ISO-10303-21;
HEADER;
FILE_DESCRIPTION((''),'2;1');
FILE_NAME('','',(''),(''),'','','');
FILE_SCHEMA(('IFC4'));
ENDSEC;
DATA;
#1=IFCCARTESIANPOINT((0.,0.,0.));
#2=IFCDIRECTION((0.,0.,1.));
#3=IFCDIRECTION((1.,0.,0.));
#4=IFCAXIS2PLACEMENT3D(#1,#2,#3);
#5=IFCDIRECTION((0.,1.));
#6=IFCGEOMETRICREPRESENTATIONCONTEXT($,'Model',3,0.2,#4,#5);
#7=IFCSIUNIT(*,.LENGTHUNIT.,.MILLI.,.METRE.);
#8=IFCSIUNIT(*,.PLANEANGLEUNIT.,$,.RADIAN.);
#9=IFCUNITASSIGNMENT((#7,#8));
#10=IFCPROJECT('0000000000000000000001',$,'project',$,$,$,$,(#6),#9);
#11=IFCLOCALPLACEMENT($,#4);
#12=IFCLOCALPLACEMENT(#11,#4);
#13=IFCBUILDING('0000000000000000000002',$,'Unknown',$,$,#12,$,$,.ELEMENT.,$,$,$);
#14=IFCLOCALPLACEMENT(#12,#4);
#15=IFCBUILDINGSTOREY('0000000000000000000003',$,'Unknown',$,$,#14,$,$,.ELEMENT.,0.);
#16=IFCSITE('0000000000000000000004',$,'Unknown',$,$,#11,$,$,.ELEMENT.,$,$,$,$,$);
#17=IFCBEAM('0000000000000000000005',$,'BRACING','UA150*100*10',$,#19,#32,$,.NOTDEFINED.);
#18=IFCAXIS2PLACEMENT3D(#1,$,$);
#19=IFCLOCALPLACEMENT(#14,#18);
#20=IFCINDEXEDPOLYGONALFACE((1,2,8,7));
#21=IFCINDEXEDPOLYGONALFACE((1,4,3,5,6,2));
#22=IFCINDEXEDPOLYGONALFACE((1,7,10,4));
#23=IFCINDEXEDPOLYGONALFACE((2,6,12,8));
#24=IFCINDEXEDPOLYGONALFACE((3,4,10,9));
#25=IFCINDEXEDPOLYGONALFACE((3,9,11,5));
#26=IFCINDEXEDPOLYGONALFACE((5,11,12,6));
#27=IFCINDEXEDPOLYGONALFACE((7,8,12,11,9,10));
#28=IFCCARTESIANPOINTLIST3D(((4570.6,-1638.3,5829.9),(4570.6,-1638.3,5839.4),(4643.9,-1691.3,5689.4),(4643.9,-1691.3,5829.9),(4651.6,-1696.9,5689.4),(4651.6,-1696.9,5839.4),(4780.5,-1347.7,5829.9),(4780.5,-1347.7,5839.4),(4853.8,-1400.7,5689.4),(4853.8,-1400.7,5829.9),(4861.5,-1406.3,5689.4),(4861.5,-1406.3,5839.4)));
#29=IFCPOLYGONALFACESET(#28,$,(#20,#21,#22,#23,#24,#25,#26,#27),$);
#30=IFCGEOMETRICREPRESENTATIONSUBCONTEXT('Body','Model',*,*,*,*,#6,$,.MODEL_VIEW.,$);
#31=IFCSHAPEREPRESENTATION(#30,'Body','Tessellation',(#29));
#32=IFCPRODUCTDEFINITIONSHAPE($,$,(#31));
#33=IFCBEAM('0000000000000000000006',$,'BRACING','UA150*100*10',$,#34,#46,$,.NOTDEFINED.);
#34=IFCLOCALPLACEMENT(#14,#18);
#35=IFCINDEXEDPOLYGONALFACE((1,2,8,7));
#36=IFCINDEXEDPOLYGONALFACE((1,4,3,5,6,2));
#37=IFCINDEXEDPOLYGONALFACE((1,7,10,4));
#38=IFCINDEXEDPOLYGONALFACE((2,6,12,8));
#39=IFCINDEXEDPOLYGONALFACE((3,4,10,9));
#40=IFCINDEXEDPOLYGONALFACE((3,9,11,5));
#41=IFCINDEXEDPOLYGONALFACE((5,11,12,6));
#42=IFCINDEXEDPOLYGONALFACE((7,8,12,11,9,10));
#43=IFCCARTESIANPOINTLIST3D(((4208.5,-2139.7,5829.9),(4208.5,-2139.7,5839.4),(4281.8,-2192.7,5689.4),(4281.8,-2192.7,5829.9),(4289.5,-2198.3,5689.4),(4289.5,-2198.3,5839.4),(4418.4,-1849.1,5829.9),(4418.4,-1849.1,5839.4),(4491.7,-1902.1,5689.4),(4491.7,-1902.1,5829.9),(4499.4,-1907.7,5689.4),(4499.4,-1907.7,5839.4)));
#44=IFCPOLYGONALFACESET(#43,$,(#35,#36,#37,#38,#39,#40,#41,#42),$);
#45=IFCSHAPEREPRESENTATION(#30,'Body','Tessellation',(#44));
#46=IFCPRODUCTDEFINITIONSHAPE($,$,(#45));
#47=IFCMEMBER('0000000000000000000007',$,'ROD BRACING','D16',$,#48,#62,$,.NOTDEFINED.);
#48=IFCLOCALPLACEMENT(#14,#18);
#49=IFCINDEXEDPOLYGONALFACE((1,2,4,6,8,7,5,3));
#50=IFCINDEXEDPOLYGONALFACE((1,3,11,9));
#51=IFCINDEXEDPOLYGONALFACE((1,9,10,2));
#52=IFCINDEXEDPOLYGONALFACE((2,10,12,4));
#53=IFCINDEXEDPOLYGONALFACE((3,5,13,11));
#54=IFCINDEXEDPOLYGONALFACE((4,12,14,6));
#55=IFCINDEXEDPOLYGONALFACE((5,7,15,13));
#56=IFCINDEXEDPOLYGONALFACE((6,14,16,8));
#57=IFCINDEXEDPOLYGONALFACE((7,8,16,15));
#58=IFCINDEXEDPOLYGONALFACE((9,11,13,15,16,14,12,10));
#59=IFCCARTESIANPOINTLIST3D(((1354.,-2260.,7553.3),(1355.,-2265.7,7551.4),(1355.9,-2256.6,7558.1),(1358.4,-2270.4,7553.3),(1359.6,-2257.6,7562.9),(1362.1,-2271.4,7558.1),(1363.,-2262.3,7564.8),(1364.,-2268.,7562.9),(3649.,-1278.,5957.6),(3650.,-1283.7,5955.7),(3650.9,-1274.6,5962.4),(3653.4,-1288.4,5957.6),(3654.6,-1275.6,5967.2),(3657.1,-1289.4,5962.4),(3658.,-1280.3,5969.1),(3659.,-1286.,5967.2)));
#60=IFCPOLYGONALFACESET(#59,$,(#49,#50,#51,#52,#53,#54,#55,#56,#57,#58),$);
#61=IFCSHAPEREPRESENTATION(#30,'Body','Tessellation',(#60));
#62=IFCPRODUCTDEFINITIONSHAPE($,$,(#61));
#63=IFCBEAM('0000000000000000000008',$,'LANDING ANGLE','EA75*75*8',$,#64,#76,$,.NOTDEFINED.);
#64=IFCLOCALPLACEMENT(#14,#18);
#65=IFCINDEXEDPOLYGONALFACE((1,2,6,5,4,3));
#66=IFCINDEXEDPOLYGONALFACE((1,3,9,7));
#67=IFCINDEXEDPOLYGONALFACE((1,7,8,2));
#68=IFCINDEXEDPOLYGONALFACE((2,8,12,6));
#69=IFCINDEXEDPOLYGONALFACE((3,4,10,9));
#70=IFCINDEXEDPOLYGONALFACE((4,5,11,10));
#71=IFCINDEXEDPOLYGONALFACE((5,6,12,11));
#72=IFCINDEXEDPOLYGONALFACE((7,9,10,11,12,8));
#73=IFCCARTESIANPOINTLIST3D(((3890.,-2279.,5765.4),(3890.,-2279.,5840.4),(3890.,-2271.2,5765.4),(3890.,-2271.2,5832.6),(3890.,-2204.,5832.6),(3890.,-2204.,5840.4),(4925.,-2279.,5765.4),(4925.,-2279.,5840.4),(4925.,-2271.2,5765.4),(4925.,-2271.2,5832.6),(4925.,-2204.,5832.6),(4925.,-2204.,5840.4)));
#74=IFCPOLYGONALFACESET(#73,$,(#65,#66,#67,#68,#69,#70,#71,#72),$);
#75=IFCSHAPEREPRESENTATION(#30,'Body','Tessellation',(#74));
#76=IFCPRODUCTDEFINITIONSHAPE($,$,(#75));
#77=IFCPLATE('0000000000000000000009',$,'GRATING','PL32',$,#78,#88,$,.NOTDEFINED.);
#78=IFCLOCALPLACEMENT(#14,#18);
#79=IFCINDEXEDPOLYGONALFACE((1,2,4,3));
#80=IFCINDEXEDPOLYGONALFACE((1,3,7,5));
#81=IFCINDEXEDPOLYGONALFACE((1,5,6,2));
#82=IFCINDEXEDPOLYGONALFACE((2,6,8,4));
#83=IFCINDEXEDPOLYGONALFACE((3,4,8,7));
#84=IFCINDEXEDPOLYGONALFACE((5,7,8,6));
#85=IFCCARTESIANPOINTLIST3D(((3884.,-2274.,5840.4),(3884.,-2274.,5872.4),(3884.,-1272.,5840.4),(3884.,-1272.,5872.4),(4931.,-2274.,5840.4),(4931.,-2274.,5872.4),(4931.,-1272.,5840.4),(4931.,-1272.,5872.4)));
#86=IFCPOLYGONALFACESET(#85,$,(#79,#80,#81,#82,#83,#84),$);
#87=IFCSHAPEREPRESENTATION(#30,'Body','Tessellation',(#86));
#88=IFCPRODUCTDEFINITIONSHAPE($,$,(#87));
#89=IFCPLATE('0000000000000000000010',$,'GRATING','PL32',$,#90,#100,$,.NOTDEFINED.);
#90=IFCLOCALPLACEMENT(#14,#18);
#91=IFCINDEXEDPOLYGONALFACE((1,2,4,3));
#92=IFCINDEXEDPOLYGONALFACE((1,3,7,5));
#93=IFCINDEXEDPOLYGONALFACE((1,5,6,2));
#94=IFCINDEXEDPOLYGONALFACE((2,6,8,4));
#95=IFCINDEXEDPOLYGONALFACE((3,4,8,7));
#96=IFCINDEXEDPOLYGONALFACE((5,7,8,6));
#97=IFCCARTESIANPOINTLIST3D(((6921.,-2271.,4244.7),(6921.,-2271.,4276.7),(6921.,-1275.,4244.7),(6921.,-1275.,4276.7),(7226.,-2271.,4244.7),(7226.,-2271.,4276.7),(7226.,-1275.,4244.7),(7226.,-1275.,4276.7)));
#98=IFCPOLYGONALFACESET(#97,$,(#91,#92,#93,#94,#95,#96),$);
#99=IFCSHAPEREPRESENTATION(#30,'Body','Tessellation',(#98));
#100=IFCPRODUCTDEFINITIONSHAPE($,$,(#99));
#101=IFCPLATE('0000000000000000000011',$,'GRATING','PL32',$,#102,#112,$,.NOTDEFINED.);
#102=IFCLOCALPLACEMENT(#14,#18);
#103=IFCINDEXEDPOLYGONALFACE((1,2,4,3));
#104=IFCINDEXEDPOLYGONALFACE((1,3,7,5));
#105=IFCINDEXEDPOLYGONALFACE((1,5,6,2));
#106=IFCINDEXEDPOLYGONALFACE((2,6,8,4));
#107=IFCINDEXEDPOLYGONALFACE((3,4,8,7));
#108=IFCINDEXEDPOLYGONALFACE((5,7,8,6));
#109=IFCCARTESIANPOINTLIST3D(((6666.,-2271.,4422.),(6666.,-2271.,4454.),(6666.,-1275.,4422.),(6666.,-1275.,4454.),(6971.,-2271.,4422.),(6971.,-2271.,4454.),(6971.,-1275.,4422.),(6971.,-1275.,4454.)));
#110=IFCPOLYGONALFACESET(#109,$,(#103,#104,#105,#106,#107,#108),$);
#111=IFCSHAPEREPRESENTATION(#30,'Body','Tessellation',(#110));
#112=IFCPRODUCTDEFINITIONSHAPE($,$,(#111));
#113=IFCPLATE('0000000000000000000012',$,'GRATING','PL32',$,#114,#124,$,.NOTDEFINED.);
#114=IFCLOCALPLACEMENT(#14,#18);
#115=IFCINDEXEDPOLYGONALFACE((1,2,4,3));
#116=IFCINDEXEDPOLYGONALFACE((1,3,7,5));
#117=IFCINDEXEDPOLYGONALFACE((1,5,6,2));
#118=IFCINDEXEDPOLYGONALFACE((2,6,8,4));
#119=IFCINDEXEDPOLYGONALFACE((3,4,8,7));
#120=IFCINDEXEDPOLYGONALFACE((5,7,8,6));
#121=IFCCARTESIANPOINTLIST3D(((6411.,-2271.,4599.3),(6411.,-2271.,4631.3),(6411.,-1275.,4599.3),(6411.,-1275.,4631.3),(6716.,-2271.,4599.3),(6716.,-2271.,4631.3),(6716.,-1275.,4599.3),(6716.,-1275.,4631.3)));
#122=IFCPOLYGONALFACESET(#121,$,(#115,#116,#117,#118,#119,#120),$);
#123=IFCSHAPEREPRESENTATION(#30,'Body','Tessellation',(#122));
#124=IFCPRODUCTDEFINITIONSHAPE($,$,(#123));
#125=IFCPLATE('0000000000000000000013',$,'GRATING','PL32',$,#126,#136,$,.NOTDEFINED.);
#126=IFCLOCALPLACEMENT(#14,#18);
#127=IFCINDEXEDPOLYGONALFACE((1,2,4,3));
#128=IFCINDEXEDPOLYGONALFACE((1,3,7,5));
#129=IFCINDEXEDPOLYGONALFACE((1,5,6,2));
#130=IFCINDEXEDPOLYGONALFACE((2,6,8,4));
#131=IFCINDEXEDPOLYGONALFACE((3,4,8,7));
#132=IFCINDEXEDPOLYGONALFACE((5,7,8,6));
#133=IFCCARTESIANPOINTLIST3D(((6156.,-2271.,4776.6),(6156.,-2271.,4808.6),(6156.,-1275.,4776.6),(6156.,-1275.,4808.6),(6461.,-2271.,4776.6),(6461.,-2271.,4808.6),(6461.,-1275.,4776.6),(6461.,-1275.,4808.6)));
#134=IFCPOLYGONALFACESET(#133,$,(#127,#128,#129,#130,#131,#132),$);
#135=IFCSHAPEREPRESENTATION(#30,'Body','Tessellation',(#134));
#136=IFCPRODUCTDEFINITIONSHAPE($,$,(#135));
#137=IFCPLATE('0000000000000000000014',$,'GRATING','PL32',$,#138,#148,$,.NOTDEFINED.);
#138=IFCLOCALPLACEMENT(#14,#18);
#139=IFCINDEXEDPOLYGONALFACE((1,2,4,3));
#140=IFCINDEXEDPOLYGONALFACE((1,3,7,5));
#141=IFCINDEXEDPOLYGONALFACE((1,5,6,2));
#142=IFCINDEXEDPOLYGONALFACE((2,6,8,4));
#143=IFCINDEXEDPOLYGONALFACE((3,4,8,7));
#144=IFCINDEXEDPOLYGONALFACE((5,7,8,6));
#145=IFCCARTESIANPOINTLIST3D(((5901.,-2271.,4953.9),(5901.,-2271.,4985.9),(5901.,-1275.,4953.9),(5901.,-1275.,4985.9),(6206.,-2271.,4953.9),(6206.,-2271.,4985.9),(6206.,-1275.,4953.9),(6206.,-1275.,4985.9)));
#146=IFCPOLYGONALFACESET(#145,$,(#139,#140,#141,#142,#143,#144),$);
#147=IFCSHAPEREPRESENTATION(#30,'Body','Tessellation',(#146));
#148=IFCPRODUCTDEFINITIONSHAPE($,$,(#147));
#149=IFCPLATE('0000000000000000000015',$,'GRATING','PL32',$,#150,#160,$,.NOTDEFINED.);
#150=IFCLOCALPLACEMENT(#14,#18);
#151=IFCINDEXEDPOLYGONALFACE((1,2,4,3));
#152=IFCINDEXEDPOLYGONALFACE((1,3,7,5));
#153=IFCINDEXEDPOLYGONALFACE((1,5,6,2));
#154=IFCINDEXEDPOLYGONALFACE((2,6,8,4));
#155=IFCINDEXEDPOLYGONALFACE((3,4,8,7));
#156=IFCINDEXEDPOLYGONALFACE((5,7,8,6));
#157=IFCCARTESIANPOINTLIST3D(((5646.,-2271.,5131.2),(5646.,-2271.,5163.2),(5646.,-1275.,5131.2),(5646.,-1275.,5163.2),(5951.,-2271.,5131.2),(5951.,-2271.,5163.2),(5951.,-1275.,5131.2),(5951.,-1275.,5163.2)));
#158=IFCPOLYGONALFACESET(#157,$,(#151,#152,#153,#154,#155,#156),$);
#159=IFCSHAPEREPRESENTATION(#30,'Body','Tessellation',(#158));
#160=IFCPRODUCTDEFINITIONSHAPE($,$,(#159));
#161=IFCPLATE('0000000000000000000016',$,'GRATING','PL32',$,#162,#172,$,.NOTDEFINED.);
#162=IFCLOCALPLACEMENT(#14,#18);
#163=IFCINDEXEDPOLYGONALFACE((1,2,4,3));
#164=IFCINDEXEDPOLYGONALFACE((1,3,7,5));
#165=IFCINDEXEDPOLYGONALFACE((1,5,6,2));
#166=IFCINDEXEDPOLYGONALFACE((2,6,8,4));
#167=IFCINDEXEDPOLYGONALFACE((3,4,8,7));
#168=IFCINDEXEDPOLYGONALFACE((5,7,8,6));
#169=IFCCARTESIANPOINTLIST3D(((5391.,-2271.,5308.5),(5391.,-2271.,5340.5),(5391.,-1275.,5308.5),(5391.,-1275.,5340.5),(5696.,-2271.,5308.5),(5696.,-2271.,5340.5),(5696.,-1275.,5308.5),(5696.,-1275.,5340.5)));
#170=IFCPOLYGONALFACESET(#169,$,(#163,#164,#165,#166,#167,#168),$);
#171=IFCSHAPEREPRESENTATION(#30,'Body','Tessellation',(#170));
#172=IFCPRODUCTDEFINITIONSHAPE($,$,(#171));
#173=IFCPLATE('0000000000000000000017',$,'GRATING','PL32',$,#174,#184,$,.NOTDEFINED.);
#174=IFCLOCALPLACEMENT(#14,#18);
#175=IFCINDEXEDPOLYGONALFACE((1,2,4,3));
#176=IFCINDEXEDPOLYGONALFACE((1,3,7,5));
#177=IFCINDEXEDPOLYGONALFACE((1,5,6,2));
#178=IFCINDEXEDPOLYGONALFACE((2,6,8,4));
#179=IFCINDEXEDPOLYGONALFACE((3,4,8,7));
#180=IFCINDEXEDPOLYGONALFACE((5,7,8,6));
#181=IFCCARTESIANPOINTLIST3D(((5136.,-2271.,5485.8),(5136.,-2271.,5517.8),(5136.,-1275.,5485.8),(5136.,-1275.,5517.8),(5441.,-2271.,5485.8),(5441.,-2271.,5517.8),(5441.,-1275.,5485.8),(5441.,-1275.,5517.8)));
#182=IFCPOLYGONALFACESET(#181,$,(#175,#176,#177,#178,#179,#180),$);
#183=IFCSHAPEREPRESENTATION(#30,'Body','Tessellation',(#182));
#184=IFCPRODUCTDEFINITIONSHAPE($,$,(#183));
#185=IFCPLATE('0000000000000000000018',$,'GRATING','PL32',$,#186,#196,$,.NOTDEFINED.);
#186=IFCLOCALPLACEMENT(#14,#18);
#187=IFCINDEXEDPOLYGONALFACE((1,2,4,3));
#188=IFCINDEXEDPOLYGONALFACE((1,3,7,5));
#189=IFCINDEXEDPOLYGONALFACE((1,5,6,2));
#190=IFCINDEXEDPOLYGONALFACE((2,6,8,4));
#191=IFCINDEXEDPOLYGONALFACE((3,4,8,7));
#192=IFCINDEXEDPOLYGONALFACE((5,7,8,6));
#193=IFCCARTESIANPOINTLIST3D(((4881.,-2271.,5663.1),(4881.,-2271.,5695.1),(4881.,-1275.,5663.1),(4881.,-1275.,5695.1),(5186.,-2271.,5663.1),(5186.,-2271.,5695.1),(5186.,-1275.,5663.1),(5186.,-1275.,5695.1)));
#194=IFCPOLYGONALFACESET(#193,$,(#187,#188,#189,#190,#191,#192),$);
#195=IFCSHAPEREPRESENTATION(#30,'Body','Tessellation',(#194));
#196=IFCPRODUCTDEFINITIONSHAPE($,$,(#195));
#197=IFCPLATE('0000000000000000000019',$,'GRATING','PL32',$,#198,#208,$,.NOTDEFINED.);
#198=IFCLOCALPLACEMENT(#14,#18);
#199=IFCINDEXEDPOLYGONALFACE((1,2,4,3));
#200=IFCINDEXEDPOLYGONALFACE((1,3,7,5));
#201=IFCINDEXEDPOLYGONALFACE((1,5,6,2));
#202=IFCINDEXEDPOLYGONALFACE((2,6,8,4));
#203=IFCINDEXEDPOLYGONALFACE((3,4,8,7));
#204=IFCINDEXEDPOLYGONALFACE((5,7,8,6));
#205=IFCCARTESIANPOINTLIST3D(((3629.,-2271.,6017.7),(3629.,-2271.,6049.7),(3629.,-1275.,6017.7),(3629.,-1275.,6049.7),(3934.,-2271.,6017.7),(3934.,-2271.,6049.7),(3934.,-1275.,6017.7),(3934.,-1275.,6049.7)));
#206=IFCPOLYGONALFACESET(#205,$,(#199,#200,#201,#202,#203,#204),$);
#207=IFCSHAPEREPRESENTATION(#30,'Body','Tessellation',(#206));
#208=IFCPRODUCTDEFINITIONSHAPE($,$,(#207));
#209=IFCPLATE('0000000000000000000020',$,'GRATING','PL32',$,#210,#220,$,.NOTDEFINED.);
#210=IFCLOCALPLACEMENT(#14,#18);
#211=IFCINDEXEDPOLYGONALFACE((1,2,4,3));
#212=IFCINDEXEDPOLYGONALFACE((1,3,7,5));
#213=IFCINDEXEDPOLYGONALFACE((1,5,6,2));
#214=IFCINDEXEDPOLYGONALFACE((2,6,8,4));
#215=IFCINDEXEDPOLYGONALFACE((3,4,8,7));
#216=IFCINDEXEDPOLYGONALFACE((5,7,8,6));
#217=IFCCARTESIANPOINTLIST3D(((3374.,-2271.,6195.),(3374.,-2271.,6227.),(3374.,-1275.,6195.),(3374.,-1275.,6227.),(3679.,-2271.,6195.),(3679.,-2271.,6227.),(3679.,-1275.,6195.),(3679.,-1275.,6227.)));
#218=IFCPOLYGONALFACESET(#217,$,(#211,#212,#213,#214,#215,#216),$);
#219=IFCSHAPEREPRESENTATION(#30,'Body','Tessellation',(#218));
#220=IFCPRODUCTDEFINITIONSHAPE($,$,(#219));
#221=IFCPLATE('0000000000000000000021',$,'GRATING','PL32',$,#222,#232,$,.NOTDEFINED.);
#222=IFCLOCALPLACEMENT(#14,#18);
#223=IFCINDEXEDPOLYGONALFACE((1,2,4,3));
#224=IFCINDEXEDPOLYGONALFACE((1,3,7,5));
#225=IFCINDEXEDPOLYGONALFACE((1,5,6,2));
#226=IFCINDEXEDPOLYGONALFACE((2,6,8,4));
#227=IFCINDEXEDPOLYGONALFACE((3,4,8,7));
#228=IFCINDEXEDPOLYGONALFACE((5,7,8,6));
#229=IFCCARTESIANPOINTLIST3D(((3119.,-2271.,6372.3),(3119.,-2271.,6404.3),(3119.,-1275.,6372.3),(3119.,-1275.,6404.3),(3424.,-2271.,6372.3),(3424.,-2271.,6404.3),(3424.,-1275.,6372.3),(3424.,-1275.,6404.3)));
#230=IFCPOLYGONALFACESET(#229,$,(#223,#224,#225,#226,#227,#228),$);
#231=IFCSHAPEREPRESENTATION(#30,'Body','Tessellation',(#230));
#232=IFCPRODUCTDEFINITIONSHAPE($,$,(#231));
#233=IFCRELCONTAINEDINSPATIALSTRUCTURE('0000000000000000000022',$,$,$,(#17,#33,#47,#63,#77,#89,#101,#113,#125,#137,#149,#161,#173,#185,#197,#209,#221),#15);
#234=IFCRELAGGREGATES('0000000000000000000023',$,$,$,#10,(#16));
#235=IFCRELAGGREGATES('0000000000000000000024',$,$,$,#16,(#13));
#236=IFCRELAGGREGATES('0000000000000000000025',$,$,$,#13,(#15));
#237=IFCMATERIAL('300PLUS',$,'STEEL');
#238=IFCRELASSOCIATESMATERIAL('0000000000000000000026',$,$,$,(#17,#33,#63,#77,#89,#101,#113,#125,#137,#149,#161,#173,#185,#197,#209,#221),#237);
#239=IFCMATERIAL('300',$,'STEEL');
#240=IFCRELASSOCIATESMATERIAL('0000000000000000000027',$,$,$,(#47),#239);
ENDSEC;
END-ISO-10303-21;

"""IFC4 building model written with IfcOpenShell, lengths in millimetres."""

from ifc_helpers import new_model, si_unit, direction, frame, origin_with_axes, place, context, subcontext, project, spatial, line, indexed_curve, outline, extrude, material, element, save


model = new_model("IFC4")

# Units and contexts
model_context = context("Model", 3, precision=0.2, world=origin_with_axes(), true_north=direction((0.0, 1.0)))
body_context = subcontext(model_context, "Body", "Model", "MODEL_VIEW")
ifc_project = project(units=[si_unit("LENGTHUNIT", "METRE", prefix="MILLI"), si_unit("PLANEANGLEUNIT", "RADIAN")], contexts=[model_context])

# Site, building, storey
site_placement = place(None, origin_with_axes())
site = spatial("IfcSite", under=ifc_project, at=site_placement, Name="Unknown", CompositionType="ELEMENT")
building_placement = place(site_placement, origin_with_axes())
building = spatial("IfcBuilding", under=site, at=building_placement, Name="Unknown", CompositionType="ELEMENT")
storey_placement = place(building_placement, origin_with_axes())
storey = spatial("IfcBuildingStorey", under=building, at=storey_placement, Name="Unknown", CompositionType="ELEMENT", Elevation=0.0)

# Beams
ifc_material_1 = material(Name="300PLUS", Category="STEEL")
for number, where, z_axis, x_axis, name in (
    (1, (4611.1, -1667.6, 5764.4), (-0.81065, 0.585531, 0.0), (0.585531, 0.81065, 0.0), "BRACING"),
    (2, (4249.0, -2169.0, 5764.4), (-0.81065, 0.585531, 0.0), (0.585531, 0.81065, 0.0), "BRACING"),
):
    element("IfcBeam", number, at=place(storey_placement, frame(where, z_axis=z_axis, x_axis=x_axis)), inside=storey, material=ifc_material_1, Name=name, Description="UA150*100*10", PredefinedType="NOTDEFINED", context=body_context, shape_type="SolidModel", body=[
        extrude(outline(indexed_curve([(-50.0, -75.0), (50.0, -75.0), (50.0, -65.5), (-40.5, -65.5), (-40.5, 75.0), (-50.0, 75.0)], segments=[line(1, 2, 3, 4, 5, 6, 1)])), frame((0.0, 0.0, 0.0), z_axis=(-1.0, 0.0, 0.0), x_axis=(0.0, 0.0, 1.0)), (0.0, 0.0, -1.0), 358.5),
    ])

# Member
ifc_material_2 = material(Name="300", Category="STEEL")
member_placement = place(storey_placement, frame((1359.0, -2264.0, 7558.1), z_axis=(0.495171, 0.211877, 0.842564), x_axis=(0.774631, 0.331454, -0.538596)))
element("IfcMember", 3, at=member_placement, inside=storey, material=ifc_material_2, Name="ROD BRACING", Description="D16", PredefinedType="NOTDEFINED", context=body_context, shape_type="SolidModel", body=[
    extrude(outline(indexed_curve([(8.0, 0.0), (5.7, 5.7), (0.0, 8.0), (-5.7, 5.7), (-8.0, 0.0), (-5.7, -5.7), (0.0, -8.0), (5.7, -5.7)], segments=[line(1, 2, 3, 4, 5, 6, 7, 8, 1)])), frame((0.0, 0.0, 0.0), z_axis=(-1.0, 0.0, 0.0), x_axis=(0.0, 0.0, 1.0)), (0.0, 0.0, -1.0), 2962.7),
])

# Beam
beam_placement = place(storey_placement, frame((3890.0, -2241.5, 5802.9), z_axis=(0.0, 1.0, 0.0), x_axis=(1.0, 0.0, 0.0)))
element("IfcBeam", 4, at=beam_placement, inside=storey, material=ifc_material_1, Name="LANDING ANGLE", Description="EA75*75*8", PredefinedType="NOTDEFINED", context=body_context, shape_type="SolidModel", body=[
    extrude(outline(indexed_curve([(-37.5, -37.5), (37.5, -37.5), (37.5, -29.7), (-29.7, -29.7), (-29.7, 37.5), (-37.5, 37.5)], segments=[line(1, 2, 3, 4, 5, 6, 1)])), frame((0.0, 0.0, 0.0), z_axis=(-1.0, 0.0, 0.0), x_axis=(0.0, 0.0, 1.0)), (0.0, 0.0, -1.0), 1035.0),
])

# Plates
plate_1_placement = place(storey_placement, frame((3884.0, -2274.0, 5856.4), z_axis=(0.0, 0.0, 1.0), x_axis=(1.0, 0.0, 0.0)))
element("IfcPlate", 5, at=plate_1_placement, inside=storey, material=ifc_material_1, Name="GRATING", Description="PL32", PredefinedType="NOTDEFINED", context=body_context, shape_type="SolidModel", body=[
    extrude(outline(indexed_curve([(0.0, 0.0), (1047.0, 0.0), (1047.0, 1002.0), (0.0, 1002.0)], segments=[line(1, 2, 3, 4, 1)])), frame((0.0, 0.0, 16.0), z_axis=(0.0, 0.0, 1.0), x_axis=(1.0, 0.0, 0.0)), (0.0, 0.0, -1.0), 32.0),
])
for number, where, z_axis, x_axis, name in (
    (6, (6921.0, -2271.0, 4260.7), (0.0, 0.0, 1.0), (1.0, 0.0, 0.0), "GRATING"),
    (7, (6666.0, -2271.0, 4438.0), (0.0, 0.0, 1.0), (1.0, 0.0, 0.0), "GRATING"),
    (8, (6411.0, -2271.0, 4615.3), (0.0, 0.0, 1.0), (1.0, 0.0, 0.0), "GRATING"),
    (9, (6156.0, -2271.0, 4792.6), (0.0, 0.0, 1.0), (1.0, 0.0, 0.0), "GRATING"),
    (10, (5901.0, -2271.0, 4969.9), (0.0, 0.0, 1.0), (1.0, 0.0, 0.0), "GRATING"),
    (11, (5646.0, -2271.0, 5147.2), (0.0, 0.0, 1.0), (1.0, 0.0, 0.0), "GRATING"),
    (12, (5391.0, -2271.0, 5324.5), (0.0, 0.0, 1.0), (1.0, 0.0, 0.0), "GRATING"),
    (13, (5136.0, -2271.0, 5501.8), (0.0, 0.0, 1.0), (1.0, 0.0, 0.0), "GRATING"),
    (14, (4881.0, -2271.0, 5679.1), (0.0, 0.0, 1.0), (1.0, 0.0, 0.0), "GRATING"),
    (15, (3629.0, -2271.0, 6033.7), (0.0, 0.0, 1.0), (1.0, 0.0, 0.0), "GRATING"),
    (16, (3374.0, -2271.0, 6211.0), (0.0, 0.0, 1.0), (1.0, 0.0, 0.0), "GRATING"),
    (17, (3119.0, -2271.0, 6388.3), (0.0, 0.0, 1.0), (1.0, 0.0, 0.0), "GRATING"),
):
    element("IfcPlate", number, at=place(storey_placement, frame(where, z_axis=z_axis, x_axis=x_axis)), inside=storey, material=ifc_material_1, Name=name, Description="PL32", PredefinedType="NOTDEFINED", context=body_context, shape_type="SolidModel", body=[
        extrude(outline(indexed_curve([(0.0, 0.0), (305.0, 0.0), (305.0, 996.0), (0.0, 996.0)], segments=[line(1, 2, 3, 4, 1)])), frame((0.0, 0.0, 16.0), z_axis=(0.0, 0.0, 1.0), x_axis=(1.0, 0.0, 0.0)), (0.0, 0.0, -1.0), 32.0),
    ])

save(model, "model.ifc")
